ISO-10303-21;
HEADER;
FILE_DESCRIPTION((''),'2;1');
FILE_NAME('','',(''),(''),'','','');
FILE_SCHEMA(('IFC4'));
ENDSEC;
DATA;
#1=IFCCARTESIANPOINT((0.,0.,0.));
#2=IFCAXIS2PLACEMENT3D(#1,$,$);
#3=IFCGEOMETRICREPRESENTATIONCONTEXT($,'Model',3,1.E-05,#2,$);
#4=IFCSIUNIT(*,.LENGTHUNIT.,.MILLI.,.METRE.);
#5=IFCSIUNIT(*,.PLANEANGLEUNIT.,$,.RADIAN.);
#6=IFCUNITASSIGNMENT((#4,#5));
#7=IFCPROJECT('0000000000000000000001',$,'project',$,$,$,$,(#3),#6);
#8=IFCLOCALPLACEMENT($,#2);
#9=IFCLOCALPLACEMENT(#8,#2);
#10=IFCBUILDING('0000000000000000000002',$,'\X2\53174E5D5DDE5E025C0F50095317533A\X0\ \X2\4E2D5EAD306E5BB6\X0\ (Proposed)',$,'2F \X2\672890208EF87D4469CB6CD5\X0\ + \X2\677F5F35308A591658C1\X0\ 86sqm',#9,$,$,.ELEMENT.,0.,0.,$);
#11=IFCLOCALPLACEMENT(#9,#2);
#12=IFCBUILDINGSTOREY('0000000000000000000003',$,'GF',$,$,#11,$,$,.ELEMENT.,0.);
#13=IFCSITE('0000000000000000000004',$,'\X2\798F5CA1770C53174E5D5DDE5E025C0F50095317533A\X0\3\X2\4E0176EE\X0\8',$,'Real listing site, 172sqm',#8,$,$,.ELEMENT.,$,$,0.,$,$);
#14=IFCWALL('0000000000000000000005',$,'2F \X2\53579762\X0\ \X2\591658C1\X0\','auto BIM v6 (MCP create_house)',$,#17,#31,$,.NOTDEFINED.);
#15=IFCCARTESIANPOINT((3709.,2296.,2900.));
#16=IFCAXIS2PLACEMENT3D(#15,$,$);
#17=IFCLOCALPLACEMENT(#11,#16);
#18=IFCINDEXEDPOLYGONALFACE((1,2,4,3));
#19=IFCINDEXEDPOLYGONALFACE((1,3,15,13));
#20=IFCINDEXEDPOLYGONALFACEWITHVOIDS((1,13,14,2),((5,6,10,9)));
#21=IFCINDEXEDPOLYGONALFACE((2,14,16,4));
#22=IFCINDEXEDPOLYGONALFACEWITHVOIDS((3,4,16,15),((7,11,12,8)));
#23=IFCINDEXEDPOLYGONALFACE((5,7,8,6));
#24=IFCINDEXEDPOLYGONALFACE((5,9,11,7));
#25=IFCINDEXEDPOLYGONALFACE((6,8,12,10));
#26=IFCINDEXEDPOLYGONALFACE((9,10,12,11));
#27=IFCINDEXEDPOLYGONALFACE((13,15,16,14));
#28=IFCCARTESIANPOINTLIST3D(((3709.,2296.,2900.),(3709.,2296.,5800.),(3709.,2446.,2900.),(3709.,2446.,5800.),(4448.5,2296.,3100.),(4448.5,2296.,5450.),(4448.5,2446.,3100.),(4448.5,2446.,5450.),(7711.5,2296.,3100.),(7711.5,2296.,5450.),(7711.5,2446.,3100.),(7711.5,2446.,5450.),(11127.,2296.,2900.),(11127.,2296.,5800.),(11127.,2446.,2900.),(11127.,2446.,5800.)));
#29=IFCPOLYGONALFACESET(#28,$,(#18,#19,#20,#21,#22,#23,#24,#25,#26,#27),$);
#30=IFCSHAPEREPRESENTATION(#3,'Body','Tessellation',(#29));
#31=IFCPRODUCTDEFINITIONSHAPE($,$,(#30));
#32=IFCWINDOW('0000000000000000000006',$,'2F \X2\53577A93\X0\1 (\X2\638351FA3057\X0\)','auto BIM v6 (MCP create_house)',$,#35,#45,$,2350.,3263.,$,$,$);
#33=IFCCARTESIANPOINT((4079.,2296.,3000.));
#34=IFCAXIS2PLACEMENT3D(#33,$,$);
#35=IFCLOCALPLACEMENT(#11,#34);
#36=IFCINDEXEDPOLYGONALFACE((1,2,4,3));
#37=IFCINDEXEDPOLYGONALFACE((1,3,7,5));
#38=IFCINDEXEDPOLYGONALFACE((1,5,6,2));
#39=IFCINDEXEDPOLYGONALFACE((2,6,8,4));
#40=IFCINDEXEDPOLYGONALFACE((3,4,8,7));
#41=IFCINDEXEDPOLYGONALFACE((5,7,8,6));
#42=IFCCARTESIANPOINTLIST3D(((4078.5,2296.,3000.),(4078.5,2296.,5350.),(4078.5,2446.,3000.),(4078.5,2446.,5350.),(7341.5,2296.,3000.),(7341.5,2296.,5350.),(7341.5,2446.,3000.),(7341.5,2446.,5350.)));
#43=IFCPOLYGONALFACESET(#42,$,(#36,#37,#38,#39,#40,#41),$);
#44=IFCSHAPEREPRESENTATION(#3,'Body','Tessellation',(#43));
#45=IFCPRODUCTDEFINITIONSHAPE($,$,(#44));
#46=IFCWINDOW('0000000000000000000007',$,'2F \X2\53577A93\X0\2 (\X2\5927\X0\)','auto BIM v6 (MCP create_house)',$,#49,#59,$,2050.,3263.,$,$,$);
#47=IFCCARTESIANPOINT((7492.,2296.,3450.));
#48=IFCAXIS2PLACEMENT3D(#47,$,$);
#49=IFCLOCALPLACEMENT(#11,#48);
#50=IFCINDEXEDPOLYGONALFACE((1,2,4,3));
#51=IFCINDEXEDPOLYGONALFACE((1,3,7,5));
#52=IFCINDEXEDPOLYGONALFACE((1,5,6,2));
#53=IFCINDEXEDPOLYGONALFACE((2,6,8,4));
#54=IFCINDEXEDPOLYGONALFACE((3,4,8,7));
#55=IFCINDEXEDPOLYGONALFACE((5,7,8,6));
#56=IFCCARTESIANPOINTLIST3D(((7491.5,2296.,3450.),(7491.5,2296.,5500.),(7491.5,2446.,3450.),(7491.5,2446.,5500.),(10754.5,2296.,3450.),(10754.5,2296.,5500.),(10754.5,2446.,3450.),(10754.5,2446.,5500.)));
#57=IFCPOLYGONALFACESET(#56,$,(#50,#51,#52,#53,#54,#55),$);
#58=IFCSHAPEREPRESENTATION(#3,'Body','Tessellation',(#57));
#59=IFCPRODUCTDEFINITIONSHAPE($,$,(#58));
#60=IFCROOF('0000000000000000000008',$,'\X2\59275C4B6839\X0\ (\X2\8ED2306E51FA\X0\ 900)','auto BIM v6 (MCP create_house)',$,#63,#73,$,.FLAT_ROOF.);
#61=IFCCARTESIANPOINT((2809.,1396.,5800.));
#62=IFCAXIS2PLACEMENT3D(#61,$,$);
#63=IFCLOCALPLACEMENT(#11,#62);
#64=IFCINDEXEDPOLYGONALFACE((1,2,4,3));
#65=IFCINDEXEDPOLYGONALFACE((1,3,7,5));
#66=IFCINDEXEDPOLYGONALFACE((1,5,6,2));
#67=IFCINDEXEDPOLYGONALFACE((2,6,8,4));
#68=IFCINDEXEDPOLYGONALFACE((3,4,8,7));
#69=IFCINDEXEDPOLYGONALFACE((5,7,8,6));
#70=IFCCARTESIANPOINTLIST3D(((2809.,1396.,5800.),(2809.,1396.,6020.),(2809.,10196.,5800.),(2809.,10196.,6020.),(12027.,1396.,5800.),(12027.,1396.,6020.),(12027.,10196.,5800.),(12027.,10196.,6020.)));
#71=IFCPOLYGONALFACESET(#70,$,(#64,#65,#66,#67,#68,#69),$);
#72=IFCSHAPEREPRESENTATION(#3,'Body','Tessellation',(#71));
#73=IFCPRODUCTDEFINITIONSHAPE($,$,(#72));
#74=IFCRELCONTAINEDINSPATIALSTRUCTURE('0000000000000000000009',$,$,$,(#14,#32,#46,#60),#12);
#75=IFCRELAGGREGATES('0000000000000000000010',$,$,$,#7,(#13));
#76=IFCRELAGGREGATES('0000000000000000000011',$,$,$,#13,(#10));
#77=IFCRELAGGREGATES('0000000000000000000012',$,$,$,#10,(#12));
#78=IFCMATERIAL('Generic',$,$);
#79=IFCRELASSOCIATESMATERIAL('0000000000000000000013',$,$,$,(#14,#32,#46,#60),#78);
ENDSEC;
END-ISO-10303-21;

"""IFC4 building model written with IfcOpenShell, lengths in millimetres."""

from ifc_helpers import new_model, si_unit, frame, frame_2d, origin, place, context, project, spatial, rectangle, extrude, material, element, fill, save


model = new_model("IFC4")

# Units and contexts
model_context = context("Model", 3, precision=1e-05, world=origin())
ifc_project = project(units=[si_unit("LENGTHUNIT", "METRE", prefix="MILLI"), si_unit("PLANEANGLEUNIT", "RADIAN")], contexts=[model_context])

# Site, building, storey
site_placement = place(None, origin())
site = spatial("IfcSite", under=ifc_project, at=site_placement, Name="福岡県北九州市小倉北区3丁目8", ObjectType="Real listing site, 172sqm", CompositionType="ELEMENT", RefElevation=0.0)
building_placement = place(site_placement, origin())
building = spatial("IfcBuilding", under=site, at=building_placement, Name="北九州市小倉北区 中庭の家 (Proposed)", ObjectType="2F 木造軸組構法 + 板張り外壁 86sqm", CompositionType="ELEMENT", ElevationOfRefHeight=0.0, ElevationOfTerrain=0.0)
storey_placement = place(building_placement, origin())
storey = spatial("IfcBuildingStorey", under=building, at=storey_placement, Name="GF", CompositionType="ELEMENT", Elevation=0.0)

# Shared definitions
ifc_material = material(Name="Generic")

# Wall, openings, windows
wall_1_placement = place(storey_placement, frame((3709.0, 2296.0, 2900.0)))
wall_1 = element("IfcWall", 1, at=wall_1_placement, inside=storey, material=ifc_material, Name="2F 南面 外壁", Description="auto BIM v6 (MCP create_house)", PredefinedType="NOTDEFINED", context=model_context, shape_type="SweptSolid", body=[
    extrude(rectangle(XDim=7418.0, YDim=150.0, at=frame_2d((3709.0, 75.0))), frame((3709.0, 2296.0, 2900.0)), (0.0, 0.0, 1.0), 2900.0),
])
opening_1_placement = place(storey_placement, frame((4079.0, 2296.0, 3000.0)))
opening_1 = element("IfcOpeningElement", 2, at=opening_1_placement, cuts=wall_1, PredefinedType="NOTDEFINED", context=model_context, shape_type="SweptSolid", body=[
    extrude(rectangle(XDim=3263.0, YDim=150.0, at=frame_2d((1631.0, 75.0))), frame((4079.0, 2296.0, 3000.0)), (0.0, 0.0, 1.0), 2350.0),
])
opening_2_placement = place(storey_placement, frame((7492.0, 2296.0, 3450.0)))
opening_2 = element("IfcOpeningElement", 3, at=opening_2_placement, cuts=wall_1, PredefinedType="NOTDEFINED", context=model_context, shape_type="SweptSolid", body=[
    extrude(rectangle(XDim=3263.0, YDim=150.0, at=frame_2d((1631.0, 75.0))), frame((7492.0, 2296.0, 3450.0)), (0.0, 0.0, 1.0), 2050.0),
])
window_1_placement = place(storey_placement, frame((4079.0, 2296.0, 3000.0)))
window_1 = element("IfcWindow", 4, at=window_1_placement, inside=storey, material=ifc_material, Name="2F 南窓1 (掃出し)", Description="auto BIM v6 (MCP create_house)", OverallHeight=2350.0, OverallWidth=3263.0, context=model_context, shape_type="SweptSolid", body=[
    extrude(rectangle(XDim=3263.0, YDim=150.0, at=frame_2d((1631.0, 75.0))), frame((4079.0, 2296.0, 3000.0)), (0.0, 0.0, 1.0), 2350.0),
])
fill(opening_1, window_1)
window_2_placement = place(storey_placement, frame((7492.0, 2296.0, 3450.0)))
window_2 = element("IfcWindow", 5, at=window_2_placement, inside=storey, material=ifc_material, Name="2F 南窓2 (大)", Description="auto BIM v6 (MCP create_house)", OverallHeight=2050.0, OverallWidth=3263.0, context=model_context, shape_type="SweptSolid", body=[
    extrude(rectangle(XDim=3263.0, YDim=150.0, at=frame_2d((1631.0, 75.0))), frame((7492.0, 2296.0, 3450.0)), (0.0, 0.0, 1.0), 2050.0),
])
fill(opening_2, window_2)

# Roof
roof_placement = place(storey_placement, frame((2809.0, 1396.0, 5800.0)))
element("IfcRoof", 6, at=roof_placement, inside=storey, material=ifc_material, Name="大屋根 (軒の出 900)", Description="auto BIM v6 (MCP create_house)", PredefinedType="FLAT_ROOF", context=model_context, shape_type="SweptSolid", body=[
    extrude(rectangle(XDim=9218.0, YDim=8800.0, at=frame_2d((4609.0, 4400.0))), frame((2809.0, 1396.0, 5800.0)), (0.0, 0.0, 1.0), 220.0),
])

save(model, "model.ifc")
